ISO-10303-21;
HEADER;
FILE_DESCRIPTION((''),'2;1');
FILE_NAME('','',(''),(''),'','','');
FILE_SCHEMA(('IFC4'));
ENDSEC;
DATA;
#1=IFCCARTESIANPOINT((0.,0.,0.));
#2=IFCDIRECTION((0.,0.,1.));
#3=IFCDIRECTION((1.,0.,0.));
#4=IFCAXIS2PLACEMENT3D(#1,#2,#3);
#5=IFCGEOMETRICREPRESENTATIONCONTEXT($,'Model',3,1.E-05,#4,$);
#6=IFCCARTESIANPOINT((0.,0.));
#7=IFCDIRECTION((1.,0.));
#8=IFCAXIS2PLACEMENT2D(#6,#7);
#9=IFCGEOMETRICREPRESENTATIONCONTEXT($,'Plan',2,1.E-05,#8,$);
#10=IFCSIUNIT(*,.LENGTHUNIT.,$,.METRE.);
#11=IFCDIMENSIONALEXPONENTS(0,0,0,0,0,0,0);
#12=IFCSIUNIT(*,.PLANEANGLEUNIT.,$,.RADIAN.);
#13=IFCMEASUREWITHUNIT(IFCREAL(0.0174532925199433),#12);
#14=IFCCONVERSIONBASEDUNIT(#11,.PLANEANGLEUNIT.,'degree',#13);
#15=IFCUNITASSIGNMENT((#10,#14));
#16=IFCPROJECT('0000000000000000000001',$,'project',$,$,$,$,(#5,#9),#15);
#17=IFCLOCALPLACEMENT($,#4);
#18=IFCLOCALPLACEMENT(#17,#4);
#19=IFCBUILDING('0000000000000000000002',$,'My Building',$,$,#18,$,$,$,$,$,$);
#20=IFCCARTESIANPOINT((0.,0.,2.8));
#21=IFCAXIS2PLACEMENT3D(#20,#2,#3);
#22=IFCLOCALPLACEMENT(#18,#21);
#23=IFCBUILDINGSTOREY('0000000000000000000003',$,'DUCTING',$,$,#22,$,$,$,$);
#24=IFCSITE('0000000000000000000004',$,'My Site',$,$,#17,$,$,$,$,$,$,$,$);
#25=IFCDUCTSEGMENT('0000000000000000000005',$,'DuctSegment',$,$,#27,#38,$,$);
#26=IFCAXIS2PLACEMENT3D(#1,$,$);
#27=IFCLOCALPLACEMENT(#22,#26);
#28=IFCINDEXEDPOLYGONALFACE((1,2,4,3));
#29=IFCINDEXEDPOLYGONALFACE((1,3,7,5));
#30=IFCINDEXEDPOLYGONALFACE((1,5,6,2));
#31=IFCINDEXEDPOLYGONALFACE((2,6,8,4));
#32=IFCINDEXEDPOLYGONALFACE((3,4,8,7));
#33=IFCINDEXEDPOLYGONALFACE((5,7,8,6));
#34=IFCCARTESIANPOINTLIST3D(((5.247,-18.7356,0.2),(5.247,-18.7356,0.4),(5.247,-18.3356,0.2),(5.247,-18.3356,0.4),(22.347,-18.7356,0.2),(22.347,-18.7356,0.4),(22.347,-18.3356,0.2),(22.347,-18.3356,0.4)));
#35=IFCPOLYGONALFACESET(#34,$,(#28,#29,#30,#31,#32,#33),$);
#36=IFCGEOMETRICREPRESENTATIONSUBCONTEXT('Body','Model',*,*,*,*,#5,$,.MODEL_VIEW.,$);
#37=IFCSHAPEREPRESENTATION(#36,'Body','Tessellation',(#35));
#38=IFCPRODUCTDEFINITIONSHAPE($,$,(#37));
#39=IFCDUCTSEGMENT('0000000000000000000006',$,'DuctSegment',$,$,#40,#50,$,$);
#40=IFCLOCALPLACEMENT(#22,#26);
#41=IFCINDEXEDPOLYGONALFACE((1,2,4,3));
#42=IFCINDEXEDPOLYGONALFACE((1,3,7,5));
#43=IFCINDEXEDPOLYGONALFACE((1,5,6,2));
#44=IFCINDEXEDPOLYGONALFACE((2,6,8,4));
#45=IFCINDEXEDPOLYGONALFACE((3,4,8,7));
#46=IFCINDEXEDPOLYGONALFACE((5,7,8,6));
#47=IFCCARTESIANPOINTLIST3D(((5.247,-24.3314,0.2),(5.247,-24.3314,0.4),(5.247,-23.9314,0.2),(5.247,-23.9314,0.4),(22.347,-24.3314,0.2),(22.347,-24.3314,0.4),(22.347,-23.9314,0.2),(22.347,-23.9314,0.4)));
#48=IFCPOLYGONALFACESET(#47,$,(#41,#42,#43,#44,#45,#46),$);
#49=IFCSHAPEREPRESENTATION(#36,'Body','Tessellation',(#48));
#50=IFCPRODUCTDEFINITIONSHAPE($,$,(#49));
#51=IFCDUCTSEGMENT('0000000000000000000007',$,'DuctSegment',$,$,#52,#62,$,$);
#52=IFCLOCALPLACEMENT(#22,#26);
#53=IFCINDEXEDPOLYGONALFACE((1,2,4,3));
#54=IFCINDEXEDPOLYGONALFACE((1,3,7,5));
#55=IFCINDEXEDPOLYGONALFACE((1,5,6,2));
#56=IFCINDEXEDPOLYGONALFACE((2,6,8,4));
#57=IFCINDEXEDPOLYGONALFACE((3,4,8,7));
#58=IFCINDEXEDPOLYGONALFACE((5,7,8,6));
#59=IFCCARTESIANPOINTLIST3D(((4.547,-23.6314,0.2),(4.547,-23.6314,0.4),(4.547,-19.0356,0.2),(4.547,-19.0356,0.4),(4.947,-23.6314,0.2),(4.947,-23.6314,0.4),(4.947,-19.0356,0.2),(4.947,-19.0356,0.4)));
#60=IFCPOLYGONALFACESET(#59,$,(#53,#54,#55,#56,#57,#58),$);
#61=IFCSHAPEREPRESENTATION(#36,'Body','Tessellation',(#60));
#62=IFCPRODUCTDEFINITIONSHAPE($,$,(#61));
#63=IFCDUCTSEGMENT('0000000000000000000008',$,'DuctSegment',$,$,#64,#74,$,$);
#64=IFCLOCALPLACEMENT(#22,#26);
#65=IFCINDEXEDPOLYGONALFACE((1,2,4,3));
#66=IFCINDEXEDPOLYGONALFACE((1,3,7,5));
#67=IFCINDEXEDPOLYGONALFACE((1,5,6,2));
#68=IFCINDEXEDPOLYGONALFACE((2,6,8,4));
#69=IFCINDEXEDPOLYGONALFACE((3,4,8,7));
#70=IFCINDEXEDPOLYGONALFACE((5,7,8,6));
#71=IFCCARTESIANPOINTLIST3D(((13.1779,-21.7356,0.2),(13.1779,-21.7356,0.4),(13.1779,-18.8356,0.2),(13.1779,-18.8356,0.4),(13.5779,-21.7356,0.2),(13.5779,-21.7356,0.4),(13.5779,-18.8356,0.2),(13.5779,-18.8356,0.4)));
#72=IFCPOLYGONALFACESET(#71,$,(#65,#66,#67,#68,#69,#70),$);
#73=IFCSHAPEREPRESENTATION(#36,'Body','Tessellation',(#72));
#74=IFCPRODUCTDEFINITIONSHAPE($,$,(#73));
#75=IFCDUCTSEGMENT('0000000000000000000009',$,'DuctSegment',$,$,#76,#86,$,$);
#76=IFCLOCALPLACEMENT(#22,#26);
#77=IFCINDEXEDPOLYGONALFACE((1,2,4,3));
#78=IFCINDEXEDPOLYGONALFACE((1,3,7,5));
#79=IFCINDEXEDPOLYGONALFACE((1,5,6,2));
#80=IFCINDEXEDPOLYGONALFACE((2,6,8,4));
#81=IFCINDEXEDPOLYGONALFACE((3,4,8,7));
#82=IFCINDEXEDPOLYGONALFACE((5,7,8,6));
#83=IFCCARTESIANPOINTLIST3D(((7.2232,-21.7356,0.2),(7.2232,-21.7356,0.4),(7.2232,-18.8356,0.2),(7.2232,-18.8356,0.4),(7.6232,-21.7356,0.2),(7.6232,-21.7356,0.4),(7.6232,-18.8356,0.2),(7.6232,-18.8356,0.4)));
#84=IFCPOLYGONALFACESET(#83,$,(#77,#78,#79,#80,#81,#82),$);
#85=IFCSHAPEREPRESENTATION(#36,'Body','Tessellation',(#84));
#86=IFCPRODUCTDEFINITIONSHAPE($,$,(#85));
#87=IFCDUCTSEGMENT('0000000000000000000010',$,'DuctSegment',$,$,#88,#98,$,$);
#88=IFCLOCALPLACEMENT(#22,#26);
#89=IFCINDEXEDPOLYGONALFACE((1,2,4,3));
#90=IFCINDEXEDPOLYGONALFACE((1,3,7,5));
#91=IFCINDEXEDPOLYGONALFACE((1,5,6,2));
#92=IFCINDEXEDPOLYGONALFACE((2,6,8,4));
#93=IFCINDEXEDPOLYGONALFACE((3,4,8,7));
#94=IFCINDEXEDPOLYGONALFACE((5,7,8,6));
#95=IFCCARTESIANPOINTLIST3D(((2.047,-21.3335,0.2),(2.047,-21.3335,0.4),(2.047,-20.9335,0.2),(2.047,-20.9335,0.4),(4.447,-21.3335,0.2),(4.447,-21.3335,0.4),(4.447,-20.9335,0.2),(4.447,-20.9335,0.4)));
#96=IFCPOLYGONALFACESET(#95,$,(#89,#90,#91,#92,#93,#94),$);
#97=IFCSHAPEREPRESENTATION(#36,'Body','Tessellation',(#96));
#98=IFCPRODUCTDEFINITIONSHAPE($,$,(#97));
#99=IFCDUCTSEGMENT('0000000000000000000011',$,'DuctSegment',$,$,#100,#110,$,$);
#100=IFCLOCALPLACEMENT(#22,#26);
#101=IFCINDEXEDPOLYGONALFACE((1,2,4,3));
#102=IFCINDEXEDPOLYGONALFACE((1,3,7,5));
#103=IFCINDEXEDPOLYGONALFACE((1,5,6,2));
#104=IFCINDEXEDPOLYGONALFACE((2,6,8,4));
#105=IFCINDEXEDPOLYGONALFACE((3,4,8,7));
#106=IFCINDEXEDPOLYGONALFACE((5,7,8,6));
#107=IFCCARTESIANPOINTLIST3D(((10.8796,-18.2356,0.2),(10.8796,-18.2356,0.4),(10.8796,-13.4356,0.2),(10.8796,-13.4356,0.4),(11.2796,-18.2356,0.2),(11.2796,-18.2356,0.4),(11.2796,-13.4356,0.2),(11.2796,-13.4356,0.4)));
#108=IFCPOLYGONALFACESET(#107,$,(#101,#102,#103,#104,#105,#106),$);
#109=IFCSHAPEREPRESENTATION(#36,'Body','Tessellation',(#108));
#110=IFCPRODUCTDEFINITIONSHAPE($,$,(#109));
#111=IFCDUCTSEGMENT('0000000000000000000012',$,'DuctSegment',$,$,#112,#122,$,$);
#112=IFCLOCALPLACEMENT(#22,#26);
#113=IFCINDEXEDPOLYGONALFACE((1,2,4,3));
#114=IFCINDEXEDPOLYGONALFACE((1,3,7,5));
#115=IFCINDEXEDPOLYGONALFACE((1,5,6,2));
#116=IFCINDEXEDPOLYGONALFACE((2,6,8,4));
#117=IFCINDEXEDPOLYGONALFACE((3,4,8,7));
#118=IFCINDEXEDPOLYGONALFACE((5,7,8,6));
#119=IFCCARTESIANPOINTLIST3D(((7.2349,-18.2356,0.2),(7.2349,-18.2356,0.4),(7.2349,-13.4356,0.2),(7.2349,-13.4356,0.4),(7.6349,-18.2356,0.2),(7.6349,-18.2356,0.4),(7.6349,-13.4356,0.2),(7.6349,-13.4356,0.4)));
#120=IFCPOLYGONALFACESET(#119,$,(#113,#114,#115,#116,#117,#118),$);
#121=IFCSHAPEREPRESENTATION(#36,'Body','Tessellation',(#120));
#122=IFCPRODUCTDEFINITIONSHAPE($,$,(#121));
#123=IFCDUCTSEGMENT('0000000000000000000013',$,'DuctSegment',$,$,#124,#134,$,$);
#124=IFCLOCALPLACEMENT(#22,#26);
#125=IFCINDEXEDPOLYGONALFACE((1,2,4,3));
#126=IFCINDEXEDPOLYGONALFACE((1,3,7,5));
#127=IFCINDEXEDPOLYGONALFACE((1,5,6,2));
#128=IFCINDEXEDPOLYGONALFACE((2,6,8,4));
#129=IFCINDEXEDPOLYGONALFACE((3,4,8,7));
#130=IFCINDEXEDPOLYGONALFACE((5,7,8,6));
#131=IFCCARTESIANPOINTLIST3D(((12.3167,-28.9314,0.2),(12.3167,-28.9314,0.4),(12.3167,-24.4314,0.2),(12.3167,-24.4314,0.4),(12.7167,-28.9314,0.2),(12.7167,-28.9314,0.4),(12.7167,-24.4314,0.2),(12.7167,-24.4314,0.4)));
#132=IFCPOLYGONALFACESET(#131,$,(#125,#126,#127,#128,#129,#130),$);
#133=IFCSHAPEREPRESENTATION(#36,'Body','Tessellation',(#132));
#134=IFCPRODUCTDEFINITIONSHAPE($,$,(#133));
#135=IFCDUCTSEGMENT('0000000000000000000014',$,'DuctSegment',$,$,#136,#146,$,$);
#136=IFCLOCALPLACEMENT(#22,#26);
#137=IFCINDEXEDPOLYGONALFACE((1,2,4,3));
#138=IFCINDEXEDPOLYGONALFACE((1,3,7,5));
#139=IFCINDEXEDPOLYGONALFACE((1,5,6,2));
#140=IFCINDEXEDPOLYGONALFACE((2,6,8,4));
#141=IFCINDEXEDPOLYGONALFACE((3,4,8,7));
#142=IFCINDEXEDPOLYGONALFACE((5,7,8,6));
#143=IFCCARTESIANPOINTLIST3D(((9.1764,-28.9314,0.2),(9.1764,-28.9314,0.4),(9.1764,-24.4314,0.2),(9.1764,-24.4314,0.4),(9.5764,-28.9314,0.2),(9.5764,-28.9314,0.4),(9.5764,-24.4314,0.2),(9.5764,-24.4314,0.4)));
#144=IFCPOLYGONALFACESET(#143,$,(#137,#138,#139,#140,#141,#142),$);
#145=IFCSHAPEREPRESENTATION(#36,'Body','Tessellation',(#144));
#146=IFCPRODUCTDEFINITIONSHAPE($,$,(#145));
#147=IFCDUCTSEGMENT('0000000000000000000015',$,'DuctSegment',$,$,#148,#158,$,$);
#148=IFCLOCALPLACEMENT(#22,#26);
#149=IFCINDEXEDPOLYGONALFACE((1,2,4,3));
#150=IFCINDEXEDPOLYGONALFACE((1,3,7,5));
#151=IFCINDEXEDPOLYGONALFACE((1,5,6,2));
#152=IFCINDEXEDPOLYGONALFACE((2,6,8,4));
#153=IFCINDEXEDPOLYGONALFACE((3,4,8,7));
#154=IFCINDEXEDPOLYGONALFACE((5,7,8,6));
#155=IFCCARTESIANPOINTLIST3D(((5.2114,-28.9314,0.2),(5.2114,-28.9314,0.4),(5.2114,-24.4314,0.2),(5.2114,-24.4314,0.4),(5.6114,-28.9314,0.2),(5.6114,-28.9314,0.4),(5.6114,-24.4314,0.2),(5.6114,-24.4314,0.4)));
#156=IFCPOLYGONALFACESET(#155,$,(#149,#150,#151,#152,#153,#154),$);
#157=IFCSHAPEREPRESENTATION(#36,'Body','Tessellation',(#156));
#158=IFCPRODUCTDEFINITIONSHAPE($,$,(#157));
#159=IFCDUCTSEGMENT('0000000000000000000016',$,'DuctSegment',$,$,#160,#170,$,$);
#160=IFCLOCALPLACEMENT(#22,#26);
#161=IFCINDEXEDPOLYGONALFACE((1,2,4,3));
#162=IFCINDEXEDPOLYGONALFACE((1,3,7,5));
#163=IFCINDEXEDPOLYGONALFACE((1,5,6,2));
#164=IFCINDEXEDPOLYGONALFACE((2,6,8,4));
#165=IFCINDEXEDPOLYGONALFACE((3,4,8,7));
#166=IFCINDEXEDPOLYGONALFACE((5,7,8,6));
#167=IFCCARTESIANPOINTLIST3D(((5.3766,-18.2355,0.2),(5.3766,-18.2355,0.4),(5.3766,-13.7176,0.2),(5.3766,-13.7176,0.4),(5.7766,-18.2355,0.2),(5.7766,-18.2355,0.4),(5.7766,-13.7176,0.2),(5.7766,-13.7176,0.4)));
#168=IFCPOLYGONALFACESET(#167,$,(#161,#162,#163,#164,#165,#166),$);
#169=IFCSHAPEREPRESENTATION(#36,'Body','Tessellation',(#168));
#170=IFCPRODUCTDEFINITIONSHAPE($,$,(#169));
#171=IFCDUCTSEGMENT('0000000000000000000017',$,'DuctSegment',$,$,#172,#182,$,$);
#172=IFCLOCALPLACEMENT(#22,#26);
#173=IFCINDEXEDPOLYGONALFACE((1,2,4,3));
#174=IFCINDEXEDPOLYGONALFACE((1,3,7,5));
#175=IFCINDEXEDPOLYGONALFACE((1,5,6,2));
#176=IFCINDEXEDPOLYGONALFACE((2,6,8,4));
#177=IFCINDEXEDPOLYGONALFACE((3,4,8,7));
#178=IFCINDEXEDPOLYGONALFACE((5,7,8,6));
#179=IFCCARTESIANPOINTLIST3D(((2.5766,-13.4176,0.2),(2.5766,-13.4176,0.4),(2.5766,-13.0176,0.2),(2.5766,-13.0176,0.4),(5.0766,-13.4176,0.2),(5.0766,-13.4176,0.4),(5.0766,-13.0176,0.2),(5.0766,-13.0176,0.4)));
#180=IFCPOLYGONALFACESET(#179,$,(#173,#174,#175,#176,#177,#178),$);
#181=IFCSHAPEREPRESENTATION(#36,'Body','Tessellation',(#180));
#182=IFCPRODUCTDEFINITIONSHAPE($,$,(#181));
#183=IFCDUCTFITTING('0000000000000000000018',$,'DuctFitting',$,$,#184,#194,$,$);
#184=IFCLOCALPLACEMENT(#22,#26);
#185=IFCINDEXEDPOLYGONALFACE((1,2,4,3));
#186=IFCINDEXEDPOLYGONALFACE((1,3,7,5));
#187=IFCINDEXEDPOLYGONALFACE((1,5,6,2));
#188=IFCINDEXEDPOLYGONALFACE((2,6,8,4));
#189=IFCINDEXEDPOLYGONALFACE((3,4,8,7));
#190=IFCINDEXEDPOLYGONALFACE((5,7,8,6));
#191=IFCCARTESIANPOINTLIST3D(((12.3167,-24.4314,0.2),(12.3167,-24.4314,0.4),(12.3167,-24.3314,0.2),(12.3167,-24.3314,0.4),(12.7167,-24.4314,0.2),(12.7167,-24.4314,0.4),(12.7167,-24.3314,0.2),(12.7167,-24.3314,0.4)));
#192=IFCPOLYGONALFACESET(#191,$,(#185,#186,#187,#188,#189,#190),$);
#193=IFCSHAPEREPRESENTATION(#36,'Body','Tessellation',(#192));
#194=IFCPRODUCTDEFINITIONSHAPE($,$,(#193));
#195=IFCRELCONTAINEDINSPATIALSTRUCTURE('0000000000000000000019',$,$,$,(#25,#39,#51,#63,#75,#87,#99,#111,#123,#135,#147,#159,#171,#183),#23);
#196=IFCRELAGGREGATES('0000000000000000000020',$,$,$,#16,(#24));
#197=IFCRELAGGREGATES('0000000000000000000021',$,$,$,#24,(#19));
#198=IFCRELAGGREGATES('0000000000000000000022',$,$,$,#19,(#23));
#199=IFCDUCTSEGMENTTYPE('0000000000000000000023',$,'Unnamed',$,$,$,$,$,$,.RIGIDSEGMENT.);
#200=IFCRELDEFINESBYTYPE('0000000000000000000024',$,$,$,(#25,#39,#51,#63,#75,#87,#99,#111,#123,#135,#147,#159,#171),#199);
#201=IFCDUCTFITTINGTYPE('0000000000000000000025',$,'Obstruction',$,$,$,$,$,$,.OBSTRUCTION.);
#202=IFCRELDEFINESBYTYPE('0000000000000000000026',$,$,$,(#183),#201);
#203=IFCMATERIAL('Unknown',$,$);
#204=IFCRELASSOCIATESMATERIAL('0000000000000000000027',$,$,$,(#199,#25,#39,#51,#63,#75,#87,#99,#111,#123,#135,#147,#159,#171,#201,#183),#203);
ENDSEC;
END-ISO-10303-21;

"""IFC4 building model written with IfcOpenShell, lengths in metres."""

from ifc_helpers import new_model, entity, si_unit, converted_unit, frame, origin_with_axes, origin_2d_with_axis, place, context, subcontext, project, spatial, rectangle, extrude, material, material_profile, profile_set, profile_usage, type_object, element, save


model = new_model("IFC4")

# Units and contexts
model_context = context("Model", 3, precision=1e-05, world=origin_with_axes())
plan_context = context("Plan", 2, precision=1e-05, world=origin_2d_with_axis())
body_context = subcontext(model_context, "Body", "Model", "MODEL_VIEW")
ifc_project = project(units=[si_unit("LENGTHUNIT", "METRE"), converted_unit("PLANEANGLEUNIT", "degree", entity("IfcReal", 0.0174532925199433), si_unit("PLANEANGLEUNIT", "RADIAN"), dimensions=[0, 0, 0, 0, 0, 0, 0])], contexts=[model_context, plan_context])

# Site, building, storey
site_placement = place(None, origin_with_axes())
site = spatial("IfcSite", under=ifc_project, at=site_placement, Name="My Site")
building_placement = place(site_placement, origin_with_axes())
building = spatial("IfcBuilding", under=site, at=building_placement, Name="My Building")
storey_placement = place(building_placement, frame((0.0, 0.0, 2.8), z_axis=(0.0, 0.0, 1.0), x_axis=(1.0, 0.0, 0.0)))
storey = spatial("IfcBuildingStorey", under=building, at=storey_placement, Name="DUCTING")

# Duct segments
ifc_material = material(Name="Unknown")
ifc_material_profile_1 = material_profile(ifc_material, rectangle(XDim=0.4, YDim=0.2))
ifc_profile_set_1 = profile_set([ifc_material_profile_1])
ifc_profile_usage_1 = profile_usage(ifc_profile_set_1, cardinal=5)
duct_segment_type = type_object("IfcDuctSegmentType", Name="Unnamed", PredefinedType="RIGIDSEGMENT", material=ifc_profile_set_1)
duct_segment_1_placement = place(storey_placement, frame((5.247, -18.5356, 0.3), z_axis=(1.0, 0.0, 0.0), x_axis=(0.0, 1.0, 0.0)))
element("IfcDuctSegment", 1, at=duct_segment_1_placement, inside=storey, type_object=duct_segment_type, material=ifc_profile_usage_1, Name="DuctSegment", context=body_context, shape_type="SweptSolid", body=[
    extrude(rectangle(XDim=0.4, YDim=0.2), origin_with_axes(), (0.0, 0.0, 1.0), 17.1),
])
ifc_profile_usage_2 = profile_usage(ifc_profile_set_1, cardinal=5)
duct_segment_2_placement = place(storey_placement, frame((5.247, -24.1314, 0.3), z_axis=(1.0, 0.0, 0.0), x_axis=(0.0, 1.0, 0.0)))
element("IfcDuctSegment", 2, at=duct_segment_2_placement, inside=storey, type_object=duct_segment_type, material=ifc_profile_usage_2, Name="DuctSegment", context=body_context, shape_type="SweptSolid", body=[
    extrude(rectangle(XDim=0.4, YDim=0.2), origin_with_axes(), (0.0, 0.0, 1.0), 17.1),
])
ifc_profile_usage_3 = profile_usage(ifc_profile_set_1, cardinal=5)
duct_segment_3_placement = place(storey_placement, frame((4.747, -19.0356, 0.3), z_axis=(0.0, -1.0, -0.000001), x_axis=(1.0, 0.0, 0.0)))
element("IfcDuctSegment", 3, at=duct_segment_3_placement, inside=storey, type_object=duct_segment_type, material=ifc_profile_usage_3, Name="DuctSegment", context=body_context, shape_type="SweptSolid", body=[
    extrude(rectangle(XDim=0.4, YDim=0.2), origin_with_axes(), (0.0, 0.0, 1.0), 4.5959),
])
ifc_profile_usage_4 = profile_usage(ifc_profile_set_1, cardinal=5)
duct_segment_4_placement = place(storey_placement, frame((13.3779, -18.8356, 0.3), z_axis=(0.0, -1.0, 0.0), x_axis=(1.0, 0.0, 0.0)))
element("IfcDuctSegment", 4, at=duct_segment_4_placement, inside=storey, type_object=duct_segment_type, material=ifc_profile_usage_4, Name="DuctSegment", context=body_context, shape_type="SweptSolid", body=[
    extrude(rectangle(XDim=0.4, YDim=0.2), origin_with_axes(), (0.0, 0.0, 1.0), 2.9),
])
ifc_profile_usage_5 = profile_usage(ifc_profile_set_1, cardinal=5)
duct_segment_5_placement = place(storey_placement, frame((7.4232, -18.8356, 0.3), z_axis=(0.0, -1.0, 0.0), x_axis=(1.0, 0.0, 0.0)))
element("IfcDuctSegment", 5, at=duct_segment_5_placement, inside=storey, type_object=duct_segment_type, material=ifc_profile_usage_5, Name="DuctSegment", context=body_context, shape_type="SweptSolid", body=[
    extrude(rectangle(XDim=0.4, YDim=0.2), origin_with_axes(), (0.0, 0.0, 1.0), 2.9),
])
ifc_profile_usage_6 = profile_usage(ifc_profile_set_1, cardinal=5)
duct_segment_6_placement = place(storey_placement, frame((2.047, -21.1335, 0.3), z_axis=(1.0, 0.000001, 0.000001), x_axis=(-0.000001, 1.0, 0.0)))
element("IfcDuctSegment", 6, at=duct_segment_6_placement, inside=storey, type_object=duct_segment_type, material=ifc_profile_usage_6, Name="DuctSegment", context=body_context, shape_type="SweptSolid", body=[
    extrude(rectangle(XDim=0.4, YDim=0.2), origin_with_axes(), (0.0, 0.0, 1.0), 2.4),
])
ifc_profile_usage_7 = profile_usage(ifc_profile_set_1, cardinal=5)
duct_segment_7_placement = place(storey_placement, frame((11.0796, -13.4356, 0.3), z_axis=(0.0, -1.0, 0.0), x_axis=(1.0, 0.0, 0.0)))
element("IfcDuctSegment", 7, at=duct_segment_7_placement, inside=storey, type_object=duct_segment_type, material=ifc_profile_usage_7, Name="DuctSegment", context=body_context, shape_type="SweptSolid", body=[
    extrude(rectangle(XDim=0.4, YDim=0.2), origin_with_axes(), (0.0, 0.0, 1.0), 4.8),
])
ifc_profile_usage_8 = profile_usage(ifc_profile_set_1, cardinal=5)
duct_segment_8_placement = place(storey_placement, frame((7.4349, -13.4356, 0.3), z_axis=(0.0, -1.0, 0.0), x_axis=(1.0, 0.0, 0.0)))
element("IfcDuctSegment", 8, at=duct_segment_8_placement, inside=storey, type_object=duct_segment_type, material=ifc_profile_usage_8, Name="DuctSegment", context=body_context, shape_type="SweptSolid", body=[
    extrude(rectangle(XDim=0.4, YDim=0.2), origin_with_axes(), (0.0, 0.0, 1.0), 4.8),
])
ifc_profile_usage_9 = profile_usage(ifc_profile_set_1, cardinal=5)
duct_segment_9_placement = place(storey_placement, frame((12.5167, -24.4314, 0.3), z_axis=(0.0, -1.0, 0.0), x_axis=(1.0, 0.0, 0.0)))
element("IfcDuctSegment", 9, at=duct_segment_9_placement, inside=storey, type_object=duct_segment_type, material=ifc_profile_usage_9, Name="DuctSegment", context=body_context, shape_type="SweptSolid", body=[
    extrude(rectangle(XDim=0.4, YDim=0.2), origin_with_axes(), (0.0, 0.0, 1.0), 4.5),
])
ifc_profile_usage_10 = profile_usage(ifc_profile_set_1, cardinal=5)
duct_segment_10_placement = place(storey_placement, frame((9.3764, -24.4314, 0.3), z_axis=(0.0, -1.0, 0.0), x_axis=(1.0, 0.0, 0.0)))
element("IfcDuctSegment", 10, at=duct_segment_10_placement, inside=storey, type_object=duct_segment_type, material=ifc_profile_usage_10, Name="DuctSegment", context=body_context, shape_type="SweptSolid", body=[
    extrude(rectangle(XDim=0.4, YDim=0.2), origin_with_axes(), (0.0, 0.0, 1.0), 4.5),
])
ifc_profile_usage_11 = profile_usage(ifc_profile_set_1, cardinal=5)
duct_segment_11_placement = place(storey_placement, frame((5.4114, -24.4314, 0.3), z_axis=(0.0, -1.0, 0.0), x_axis=(1.0, 0.0, 0.0)))
element("IfcDuctSegment", 11, at=duct_segment_11_placement, inside=storey, type_object=duct_segment_type, material=ifc_profile_usage_11, Name="DuctSegment", context=body_context, shape_type="SweptSolid", body=[
    extrude(rectangle(XDim=0.4, YDim=0.2), origin_with_axes(), (0.0, 0.0, 1.0), 4.5),
])
ifc_profile_usage_12 = profile_usage(ifc_profile_set_1, cardinal=5)
duct_segment_12_placement = place(storey_placement, frame((5.5766, -13.7176, 0.3), z_axis=(0.0, -1.0, 0.0), x_axis=(1.0, 0.0, 0.0)))
element("IfcDuctSegment", 12, at=duct_segment_12_placement, inside=storey, type_object=duct_segment_type, material=ifc_profile_usage_12, Name="DuctSegment", context=body_context, shape_type="SweptSolid", body=[
    extrude(rectangle(XDim=0.4, YDim=0.2), origin_with_axes(), (0.0, 0.0, 1.0), 4.5179),
])
ifc_profile_usage_13 = profile_usage(ifc_profile_set_1, cardinal=5)
duct_segment_13_placement = place(storey_placement, frame((5.0766, -13.2176, 0.3), z_axis=(-1.0, 0.0, 0.0), x_axis=(0.0, -1.0, 0.0)))
element("IfcDuctSegment", 13, at=duct_segment_13_placement, inside=storey, type_object=duct_segment_type, material=ifc_profile_usage_13, Name="DuctSegment", context=body_context, shape_type="SweptSolid", body=[
    extrude(rectangle(XDim=0.4, YDim=0.2), origin_with_axes(), (0.0, 0.0, 1.0), 2.5),
])

# Duct fitting
ifc_material_profile_2 = material_profile(ifc_material, rectangle(XDim=0.4, YDim=0.2))
ifc_profile_set_2 = profile_set([ifc_material_profile_2])
ifc_profile_usage_14 = profile_usage(ifc_profile_set_2, cardinal=5)
duct_fitting_type_1 = type_object("IfcDuctFittingType", Name="Obstruction", PredefinedType="OBSTRUCTION", material=ifc_profile_set_2)
duct_fitting_1_placement = place(storey_placement, frame((12.5167, -24.3314, 0.3), z_axis=(0.0, -1.0, 0.0), x_axis=(1.0, 0.0, 0.0)))
element("IfcDuctFitting", 14, at=duct_fitting_1_placement, inside=storey, type_object=duct_fitting_type_1, material=ifc_profile_usage_14, Name="DuctFitting", context=body_context, shape_type="SweptSolid", body=[
    extrude(rectangle(XDim=0.4, YDim=0.2), origin_with_axes(), (0.0, 0.0, 1.0), 0.1),
])

save(model, "model.ifc")
